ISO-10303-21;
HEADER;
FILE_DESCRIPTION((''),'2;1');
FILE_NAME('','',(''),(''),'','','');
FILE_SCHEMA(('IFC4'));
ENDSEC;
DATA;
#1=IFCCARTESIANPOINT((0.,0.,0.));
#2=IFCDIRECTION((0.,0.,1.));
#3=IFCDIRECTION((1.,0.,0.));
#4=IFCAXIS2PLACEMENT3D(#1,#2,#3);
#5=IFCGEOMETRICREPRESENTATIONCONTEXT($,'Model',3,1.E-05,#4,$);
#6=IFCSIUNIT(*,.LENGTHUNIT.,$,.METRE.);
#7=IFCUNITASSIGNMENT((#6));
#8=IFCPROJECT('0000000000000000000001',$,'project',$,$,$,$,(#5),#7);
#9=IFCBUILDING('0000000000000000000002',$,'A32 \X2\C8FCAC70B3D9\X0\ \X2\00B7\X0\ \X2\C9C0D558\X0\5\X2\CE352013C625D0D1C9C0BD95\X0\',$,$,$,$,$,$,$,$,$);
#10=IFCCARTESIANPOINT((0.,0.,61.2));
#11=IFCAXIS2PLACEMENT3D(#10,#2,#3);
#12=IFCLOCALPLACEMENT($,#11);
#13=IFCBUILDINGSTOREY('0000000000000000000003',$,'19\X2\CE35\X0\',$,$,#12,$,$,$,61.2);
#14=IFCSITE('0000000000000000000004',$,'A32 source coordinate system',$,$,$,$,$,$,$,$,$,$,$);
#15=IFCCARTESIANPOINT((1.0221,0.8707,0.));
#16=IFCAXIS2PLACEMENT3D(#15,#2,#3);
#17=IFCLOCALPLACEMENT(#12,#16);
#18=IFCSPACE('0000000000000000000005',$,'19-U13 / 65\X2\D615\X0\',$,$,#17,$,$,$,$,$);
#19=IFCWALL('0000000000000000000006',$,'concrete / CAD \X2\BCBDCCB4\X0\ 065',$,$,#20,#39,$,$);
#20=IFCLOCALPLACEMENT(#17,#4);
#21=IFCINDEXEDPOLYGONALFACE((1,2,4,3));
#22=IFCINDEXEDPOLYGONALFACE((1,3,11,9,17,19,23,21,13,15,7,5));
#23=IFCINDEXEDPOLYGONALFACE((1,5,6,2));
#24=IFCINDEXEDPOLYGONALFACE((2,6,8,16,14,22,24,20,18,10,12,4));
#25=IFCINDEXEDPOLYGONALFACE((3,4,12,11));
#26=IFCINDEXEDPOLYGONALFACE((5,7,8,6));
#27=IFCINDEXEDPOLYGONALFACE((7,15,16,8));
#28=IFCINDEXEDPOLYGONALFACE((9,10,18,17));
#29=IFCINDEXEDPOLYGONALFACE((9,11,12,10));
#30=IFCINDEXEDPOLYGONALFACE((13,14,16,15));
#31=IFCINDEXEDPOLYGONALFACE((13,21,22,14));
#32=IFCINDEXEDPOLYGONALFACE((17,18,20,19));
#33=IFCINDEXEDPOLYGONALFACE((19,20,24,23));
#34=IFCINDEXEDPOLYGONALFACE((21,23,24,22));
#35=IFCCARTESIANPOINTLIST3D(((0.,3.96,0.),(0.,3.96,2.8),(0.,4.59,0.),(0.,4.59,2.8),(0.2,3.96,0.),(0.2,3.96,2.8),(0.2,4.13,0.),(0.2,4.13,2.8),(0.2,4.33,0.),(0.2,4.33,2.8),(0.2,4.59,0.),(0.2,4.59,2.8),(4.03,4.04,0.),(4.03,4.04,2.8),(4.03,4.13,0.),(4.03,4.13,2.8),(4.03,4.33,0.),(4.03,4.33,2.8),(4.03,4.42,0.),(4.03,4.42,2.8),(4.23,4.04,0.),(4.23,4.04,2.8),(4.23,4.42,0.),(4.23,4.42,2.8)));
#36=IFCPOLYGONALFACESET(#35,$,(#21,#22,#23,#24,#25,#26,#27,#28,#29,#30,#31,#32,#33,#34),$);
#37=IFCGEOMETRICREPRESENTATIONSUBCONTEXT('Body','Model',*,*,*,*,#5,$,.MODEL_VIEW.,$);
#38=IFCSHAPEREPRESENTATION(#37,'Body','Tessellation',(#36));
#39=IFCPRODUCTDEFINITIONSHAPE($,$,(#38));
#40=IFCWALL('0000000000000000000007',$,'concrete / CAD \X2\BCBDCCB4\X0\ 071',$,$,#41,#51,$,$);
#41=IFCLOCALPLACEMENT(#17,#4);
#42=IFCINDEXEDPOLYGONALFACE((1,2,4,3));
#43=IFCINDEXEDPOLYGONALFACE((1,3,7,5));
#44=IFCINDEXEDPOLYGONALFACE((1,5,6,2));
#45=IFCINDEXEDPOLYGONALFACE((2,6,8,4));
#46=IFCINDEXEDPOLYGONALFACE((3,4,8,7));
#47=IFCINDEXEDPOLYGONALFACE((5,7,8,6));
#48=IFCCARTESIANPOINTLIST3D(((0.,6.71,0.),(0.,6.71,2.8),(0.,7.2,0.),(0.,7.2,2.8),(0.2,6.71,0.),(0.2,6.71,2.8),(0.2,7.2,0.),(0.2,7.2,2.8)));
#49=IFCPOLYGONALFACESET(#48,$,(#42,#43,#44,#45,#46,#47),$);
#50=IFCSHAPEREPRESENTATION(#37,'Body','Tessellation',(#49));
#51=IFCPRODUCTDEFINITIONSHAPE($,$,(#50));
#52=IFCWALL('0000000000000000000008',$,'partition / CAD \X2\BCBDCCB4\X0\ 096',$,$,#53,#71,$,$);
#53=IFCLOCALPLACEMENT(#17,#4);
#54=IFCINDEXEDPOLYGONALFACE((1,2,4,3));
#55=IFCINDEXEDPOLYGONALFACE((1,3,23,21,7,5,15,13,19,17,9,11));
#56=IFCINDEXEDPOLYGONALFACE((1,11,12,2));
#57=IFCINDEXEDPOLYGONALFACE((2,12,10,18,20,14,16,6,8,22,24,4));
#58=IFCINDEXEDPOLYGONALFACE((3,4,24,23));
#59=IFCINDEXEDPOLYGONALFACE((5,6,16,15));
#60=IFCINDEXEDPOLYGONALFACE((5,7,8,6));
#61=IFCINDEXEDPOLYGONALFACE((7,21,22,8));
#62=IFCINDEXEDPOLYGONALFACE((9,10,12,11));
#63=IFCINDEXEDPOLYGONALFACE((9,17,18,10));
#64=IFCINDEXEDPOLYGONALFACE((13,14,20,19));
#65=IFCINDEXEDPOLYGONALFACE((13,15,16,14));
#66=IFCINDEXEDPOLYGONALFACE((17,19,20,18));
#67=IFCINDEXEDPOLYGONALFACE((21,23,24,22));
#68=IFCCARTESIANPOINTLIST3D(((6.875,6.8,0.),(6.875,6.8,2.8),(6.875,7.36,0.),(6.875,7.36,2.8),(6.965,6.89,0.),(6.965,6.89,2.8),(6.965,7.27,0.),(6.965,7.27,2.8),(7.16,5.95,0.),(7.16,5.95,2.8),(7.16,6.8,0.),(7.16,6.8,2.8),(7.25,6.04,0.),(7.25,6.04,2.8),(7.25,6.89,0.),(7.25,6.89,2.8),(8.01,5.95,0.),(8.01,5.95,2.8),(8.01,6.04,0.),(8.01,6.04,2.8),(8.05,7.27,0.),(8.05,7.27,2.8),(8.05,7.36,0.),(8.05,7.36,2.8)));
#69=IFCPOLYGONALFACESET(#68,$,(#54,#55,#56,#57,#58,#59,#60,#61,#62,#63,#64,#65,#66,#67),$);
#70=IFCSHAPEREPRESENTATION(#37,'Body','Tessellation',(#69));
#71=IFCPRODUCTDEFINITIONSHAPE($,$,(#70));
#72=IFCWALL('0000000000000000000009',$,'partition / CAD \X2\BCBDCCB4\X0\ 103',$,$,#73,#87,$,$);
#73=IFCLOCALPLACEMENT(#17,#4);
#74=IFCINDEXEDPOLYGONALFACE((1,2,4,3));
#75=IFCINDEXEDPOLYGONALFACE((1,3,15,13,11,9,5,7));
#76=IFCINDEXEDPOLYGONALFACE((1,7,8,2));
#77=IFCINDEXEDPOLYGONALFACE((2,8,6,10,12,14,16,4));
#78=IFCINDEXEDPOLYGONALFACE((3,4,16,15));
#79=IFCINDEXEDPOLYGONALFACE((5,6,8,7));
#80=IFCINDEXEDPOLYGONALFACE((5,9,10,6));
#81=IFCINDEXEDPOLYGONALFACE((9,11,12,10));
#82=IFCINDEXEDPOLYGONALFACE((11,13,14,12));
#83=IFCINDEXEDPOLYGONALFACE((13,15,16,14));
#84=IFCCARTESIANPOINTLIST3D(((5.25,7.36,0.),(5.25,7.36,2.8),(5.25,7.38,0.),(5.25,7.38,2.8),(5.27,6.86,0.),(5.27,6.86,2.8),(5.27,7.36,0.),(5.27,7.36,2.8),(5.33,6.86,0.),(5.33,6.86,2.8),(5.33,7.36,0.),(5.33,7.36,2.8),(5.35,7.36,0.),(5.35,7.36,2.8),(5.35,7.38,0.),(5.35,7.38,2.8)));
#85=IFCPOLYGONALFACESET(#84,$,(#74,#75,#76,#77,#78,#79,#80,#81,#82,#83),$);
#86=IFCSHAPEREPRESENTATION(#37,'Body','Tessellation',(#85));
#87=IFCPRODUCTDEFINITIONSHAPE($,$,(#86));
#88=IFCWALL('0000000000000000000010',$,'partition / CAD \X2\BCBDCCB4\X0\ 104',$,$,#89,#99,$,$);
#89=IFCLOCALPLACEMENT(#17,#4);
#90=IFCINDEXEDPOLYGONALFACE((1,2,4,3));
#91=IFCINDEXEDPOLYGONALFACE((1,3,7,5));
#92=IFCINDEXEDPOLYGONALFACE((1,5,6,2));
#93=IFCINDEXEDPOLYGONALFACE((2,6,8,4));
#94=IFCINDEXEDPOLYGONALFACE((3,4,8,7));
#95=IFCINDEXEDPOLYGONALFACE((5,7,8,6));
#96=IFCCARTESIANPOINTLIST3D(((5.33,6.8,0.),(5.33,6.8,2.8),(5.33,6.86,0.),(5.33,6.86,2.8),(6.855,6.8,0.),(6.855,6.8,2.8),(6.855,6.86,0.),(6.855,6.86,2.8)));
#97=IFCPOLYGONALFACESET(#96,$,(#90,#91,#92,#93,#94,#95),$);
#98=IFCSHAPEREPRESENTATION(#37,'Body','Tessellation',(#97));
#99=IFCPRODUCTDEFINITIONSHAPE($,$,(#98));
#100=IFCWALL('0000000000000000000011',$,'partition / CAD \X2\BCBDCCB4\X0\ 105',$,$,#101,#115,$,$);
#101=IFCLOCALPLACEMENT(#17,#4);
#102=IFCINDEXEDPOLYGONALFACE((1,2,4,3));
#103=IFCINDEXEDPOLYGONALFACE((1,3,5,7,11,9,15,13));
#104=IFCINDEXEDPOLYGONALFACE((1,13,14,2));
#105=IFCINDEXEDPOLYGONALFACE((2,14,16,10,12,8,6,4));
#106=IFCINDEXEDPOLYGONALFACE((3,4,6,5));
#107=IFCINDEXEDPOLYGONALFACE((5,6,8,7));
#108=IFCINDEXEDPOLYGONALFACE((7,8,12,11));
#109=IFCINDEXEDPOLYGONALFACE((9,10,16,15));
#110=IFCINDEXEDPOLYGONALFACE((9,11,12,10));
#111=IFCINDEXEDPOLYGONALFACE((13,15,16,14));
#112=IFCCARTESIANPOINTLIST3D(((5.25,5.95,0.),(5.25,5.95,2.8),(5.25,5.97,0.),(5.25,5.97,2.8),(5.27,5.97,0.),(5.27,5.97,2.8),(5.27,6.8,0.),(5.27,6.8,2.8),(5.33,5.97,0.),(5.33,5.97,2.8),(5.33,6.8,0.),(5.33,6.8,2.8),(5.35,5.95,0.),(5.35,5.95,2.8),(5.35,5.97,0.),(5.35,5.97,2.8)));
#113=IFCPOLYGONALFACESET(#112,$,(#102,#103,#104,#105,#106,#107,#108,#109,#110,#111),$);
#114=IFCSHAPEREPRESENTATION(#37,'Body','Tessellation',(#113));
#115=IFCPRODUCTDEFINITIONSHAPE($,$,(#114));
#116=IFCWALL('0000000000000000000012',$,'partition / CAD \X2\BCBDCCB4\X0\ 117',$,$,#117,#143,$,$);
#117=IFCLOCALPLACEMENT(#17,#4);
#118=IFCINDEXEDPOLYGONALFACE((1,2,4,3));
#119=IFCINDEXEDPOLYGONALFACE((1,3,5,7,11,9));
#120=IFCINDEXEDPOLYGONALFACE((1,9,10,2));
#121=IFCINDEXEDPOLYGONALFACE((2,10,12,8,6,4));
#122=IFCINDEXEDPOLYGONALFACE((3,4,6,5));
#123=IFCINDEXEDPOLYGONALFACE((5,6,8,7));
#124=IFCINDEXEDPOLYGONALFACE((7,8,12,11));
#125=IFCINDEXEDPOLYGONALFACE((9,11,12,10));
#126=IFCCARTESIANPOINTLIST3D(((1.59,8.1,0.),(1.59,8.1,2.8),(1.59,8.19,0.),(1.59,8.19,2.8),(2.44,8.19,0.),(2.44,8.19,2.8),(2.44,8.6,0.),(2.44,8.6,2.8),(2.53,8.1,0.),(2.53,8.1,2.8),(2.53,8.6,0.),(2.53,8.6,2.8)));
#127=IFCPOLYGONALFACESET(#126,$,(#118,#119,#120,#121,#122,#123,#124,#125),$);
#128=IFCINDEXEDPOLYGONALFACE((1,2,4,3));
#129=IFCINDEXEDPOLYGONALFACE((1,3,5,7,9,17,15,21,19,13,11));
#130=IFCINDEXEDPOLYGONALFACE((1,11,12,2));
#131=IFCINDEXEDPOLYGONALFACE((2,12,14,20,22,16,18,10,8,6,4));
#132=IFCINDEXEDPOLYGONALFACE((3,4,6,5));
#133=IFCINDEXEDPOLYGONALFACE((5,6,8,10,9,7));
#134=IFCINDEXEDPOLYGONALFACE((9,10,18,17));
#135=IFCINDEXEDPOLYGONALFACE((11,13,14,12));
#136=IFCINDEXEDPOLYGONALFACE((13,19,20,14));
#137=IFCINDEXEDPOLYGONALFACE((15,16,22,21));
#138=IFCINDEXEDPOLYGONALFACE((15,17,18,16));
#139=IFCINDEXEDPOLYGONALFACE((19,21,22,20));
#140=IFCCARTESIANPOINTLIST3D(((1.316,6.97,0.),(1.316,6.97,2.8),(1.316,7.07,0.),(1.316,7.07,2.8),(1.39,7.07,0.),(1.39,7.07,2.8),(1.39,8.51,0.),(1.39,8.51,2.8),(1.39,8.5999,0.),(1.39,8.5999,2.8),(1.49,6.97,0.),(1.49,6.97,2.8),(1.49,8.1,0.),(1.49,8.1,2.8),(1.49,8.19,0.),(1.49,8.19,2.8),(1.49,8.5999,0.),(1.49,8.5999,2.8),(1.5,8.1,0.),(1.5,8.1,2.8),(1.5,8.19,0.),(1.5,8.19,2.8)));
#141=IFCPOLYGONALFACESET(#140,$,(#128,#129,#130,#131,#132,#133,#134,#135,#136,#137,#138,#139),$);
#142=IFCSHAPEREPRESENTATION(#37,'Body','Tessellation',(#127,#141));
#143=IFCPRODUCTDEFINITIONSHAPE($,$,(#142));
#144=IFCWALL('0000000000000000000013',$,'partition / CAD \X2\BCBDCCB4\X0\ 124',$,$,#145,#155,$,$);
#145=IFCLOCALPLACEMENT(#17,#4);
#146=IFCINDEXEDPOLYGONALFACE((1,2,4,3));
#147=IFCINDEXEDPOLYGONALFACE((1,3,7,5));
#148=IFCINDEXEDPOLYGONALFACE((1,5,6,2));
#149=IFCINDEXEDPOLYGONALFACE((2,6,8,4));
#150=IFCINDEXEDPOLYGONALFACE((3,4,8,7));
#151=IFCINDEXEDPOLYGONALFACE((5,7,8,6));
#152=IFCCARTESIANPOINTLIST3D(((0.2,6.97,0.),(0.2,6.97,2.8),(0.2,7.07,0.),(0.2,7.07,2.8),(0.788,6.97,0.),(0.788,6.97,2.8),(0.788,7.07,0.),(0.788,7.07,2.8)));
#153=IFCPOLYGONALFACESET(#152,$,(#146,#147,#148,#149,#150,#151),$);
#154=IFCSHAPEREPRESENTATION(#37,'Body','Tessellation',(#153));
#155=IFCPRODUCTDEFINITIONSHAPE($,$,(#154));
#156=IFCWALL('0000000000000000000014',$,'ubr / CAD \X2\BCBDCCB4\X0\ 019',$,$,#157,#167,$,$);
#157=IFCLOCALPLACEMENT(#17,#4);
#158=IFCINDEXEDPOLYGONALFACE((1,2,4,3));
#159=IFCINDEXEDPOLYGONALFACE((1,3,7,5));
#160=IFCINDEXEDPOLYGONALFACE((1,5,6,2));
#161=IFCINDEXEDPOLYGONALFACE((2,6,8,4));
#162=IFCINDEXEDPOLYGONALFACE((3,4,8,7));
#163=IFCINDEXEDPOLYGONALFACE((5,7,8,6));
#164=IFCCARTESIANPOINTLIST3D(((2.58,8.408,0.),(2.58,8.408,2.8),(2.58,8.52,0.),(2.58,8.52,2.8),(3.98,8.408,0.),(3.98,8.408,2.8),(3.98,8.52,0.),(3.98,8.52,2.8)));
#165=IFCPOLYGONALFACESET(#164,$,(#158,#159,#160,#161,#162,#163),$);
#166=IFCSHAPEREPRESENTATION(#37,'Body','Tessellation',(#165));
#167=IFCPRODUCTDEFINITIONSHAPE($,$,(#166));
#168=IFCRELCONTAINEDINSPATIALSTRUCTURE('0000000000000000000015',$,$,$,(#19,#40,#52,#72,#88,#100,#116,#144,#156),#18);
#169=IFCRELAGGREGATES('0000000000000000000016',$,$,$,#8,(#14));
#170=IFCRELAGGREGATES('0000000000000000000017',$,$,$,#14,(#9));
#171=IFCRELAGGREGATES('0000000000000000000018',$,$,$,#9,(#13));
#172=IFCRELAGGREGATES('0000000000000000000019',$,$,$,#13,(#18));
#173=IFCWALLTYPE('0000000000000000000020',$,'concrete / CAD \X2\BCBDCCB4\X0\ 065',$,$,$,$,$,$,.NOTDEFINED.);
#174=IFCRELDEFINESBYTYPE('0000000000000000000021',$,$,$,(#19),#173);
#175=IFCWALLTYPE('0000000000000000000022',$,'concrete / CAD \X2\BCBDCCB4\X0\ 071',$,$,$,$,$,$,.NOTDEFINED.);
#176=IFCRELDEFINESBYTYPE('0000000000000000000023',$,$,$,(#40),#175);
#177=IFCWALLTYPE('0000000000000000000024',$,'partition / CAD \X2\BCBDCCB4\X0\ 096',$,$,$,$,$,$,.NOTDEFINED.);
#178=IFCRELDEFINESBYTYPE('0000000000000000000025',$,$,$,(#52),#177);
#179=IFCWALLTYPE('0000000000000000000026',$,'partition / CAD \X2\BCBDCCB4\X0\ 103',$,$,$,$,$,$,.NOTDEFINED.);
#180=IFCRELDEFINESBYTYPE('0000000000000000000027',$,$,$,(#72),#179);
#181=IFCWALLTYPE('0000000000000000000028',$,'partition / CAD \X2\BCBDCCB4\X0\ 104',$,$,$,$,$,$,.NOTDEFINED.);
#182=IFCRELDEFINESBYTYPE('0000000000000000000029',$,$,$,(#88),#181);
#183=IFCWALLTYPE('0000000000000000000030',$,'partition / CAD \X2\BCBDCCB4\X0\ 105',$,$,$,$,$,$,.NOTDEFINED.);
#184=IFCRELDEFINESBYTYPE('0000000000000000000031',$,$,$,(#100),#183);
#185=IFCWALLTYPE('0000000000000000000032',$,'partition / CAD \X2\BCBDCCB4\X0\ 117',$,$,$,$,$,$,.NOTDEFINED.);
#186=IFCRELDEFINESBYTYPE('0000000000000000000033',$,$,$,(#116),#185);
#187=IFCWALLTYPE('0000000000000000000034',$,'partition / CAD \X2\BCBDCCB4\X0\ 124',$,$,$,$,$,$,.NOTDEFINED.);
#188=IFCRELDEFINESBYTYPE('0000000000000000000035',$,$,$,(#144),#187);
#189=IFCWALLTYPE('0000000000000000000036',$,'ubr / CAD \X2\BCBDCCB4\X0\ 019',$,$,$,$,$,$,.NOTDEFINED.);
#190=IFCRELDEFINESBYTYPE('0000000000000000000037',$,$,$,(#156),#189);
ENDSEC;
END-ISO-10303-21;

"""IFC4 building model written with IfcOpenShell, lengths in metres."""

from ifc_helpers import new_model, si_unit, frame, origin, origin_with_axes, place, context, subcontext, project, spatial, polyline, outline, extrude, source, transform, mapped, type_object, type_shapes, element, save


model = new_model("IFC4")

# Units and contexts
model_context = context("Model", 3, precision=1e-05, world=origin_with_axes())
body_context = subcontext(model_context, "Body", "Model", "MODEL_VIEW")
ifc_project = project(units=[si_unit("LENGTHUNIT", "METRE")], contexts=[model_context])

# Site, building, storey, space
storey_placement = place(None, frame((0.0, 0.0, 61.2), z_axis=(0.0, 0.0, 1.0), x_axis=(1.0, 0.0, 0.0)))
space_placement = place(storey_placement, frame((1.0221, 0.8707, 0.0), z_axis=(0.0, 0.0, 1.0), x_axis=(1.0, 0.0, 0.0)))
site = spatial("IfcSite", under=ifc_project, Name="A32 source coordinate system")
building = spatial("IfcBuilding", under=site, Name="A32 주거동 · 지하5층–옥탑지붕")
storey = spatial("IfcBuildingStorey", under=building, at=storey_placement, Name="19층", Elevation=61.2)
space = spatial("IfcSpace", under=storey, at=space_placement, Name="19-U13 / 65형")

# Walls
wall_type_1 = type_object("IfcWallType", Name="concrete / CAD 벽체 065", PredefinedType="NOTDEFINED")
shared_shape_1 = source(origin(), body_context, "Body", "SweptSolid", [
    extrude(outline(polyline([(0.2, 4.59), (0.2, 4.33), (4.03, 4.33), (4.03, 4.42), (4.23, 4.42), (4.23, 4.04), (4.03, 4.04), (4.03, 4.13), (0.2, 4.13), (0.2, 3.96), (0.0, 3.96), (0.0, 4.59), (0.2, 4.59)])), origin(), (0.0, 0.0, 1.0), 2.8),
])
type_shapes(wall_type_1, [shared_shape_1])
wall_1_placement = place(space_placement, origin_with_axes())
element("IfcWall", 1, at=wall_1_placement, inside=space, type_object=wall_type_1, Name="concrete / CAD 벽체 065", context=body_context, shape_type="MappedRepresentation", body=[
    mapped(shared_shape_1, transform((0.0, 0.0, 0.0), scale=1.0)),
])
wall_type_2 = type_object("IfcWallType", Name="concrete / CAD 벽체 071", PredefinedType="NOTDEFINED")
shared_shape_2 = source(origin(), body_context, "Body", "SweptSolid", [
    extrude(outline(polyline([(0.2, 6.71), (0.0, 6.71), (0.0, 7.2), (0.2, 7.2), (0.2, 6.71)])), origin(), (0.0, 0.0, 1.0), 2.8),
])
type_shapes(wall_type_2, [shared_shape_2])
wall_2_placement = place(space_placement, origin_with_axes())
element("IfcWall", 2, at=wall_2_placement, inside=space, type_object=wall_type_2, Name="concrete / CAD 벽체 071", context=body_context, shape_type="MappedRepresentation", body=[
    mapped(shared_shape_2, transform((0.0, 0.0, 0.0), scale=1.0)),
])
wall_type_3 = type_object("IfcWallType", Name="partition / CAD 벽체 096", PredefinedType="NOTDEFINED")
shared_shape_3 = source(origin(), body_context, "Body", "SweptSolid", [
    extrude(outline(polyline([(7.25, 6.04), (8.01, 6.04), (8.01, 5.95), (7.16, 5.95), (7.16, 6.8), (6.875, 6.8), (6.875, 7.36), (8.05, 7.36), (8.05, 7.27), (6.965, 7.27), (6.965, 6.89), (7.25, 6.89), (7.25, 6.04)])), origin(), (0.0, 0.0, 1.0), 2.8),
])
type_shapes(wall_type_3, [shared_shape_3])
wall_3_placement = place(space_placement, origin_with_axes())
element("IfcWall", 3, at=wall_3_placement, inside=space, type_object=wall_type_3, Name="partition / CAD 벽체 096", context=body_context, shape_type="MappedRepresentation", body=[
    mapped(shared_shape_3, transform((0.0, 0.0, 0.0), scale=1.0)),
])
wall_type_4 = type_object("IfcWallType", Name="partition / CAD 벽체 103", PredefinedType="NOTDEFINED")
shared_shape_4 = source(origin(), body_context, "Body", "SweptSolid", [
    extrude(outline(polyline([(5.27, 7.36), (5.25, 7.36), (5.25, 7.38), (5.35, 7.38), (5.35, 7.36), (5.33, 7.36), (5.33, 6.86), (5.27, 6.86), (5.27, 7.36)])), origin(), (0.0, 0.0, 1.0), 2.8),
])
type_shapes(wall_type_4, [shared_shape_4])
wall_4_placement = place(space_placement, origin_with_axes())
element("IfcWall", 4, at=wall_4_placement, inside=space, type_object=wall_type_4, Name="partition / CAD 벽체 103", context=body_context, shape_type="MappedRepresentation", body=[
    mapped(shared_shape_4, transform((0.0, 0.0, 0.0), scale=1.0)),
])
wall_type_5 = type_object("IfcWallType", Name="partition / CAD 벽체 104", PredefinedType="NOTDEFINED")
shared_shape_5 = source(origin(), body_context, "Body", "SweptSolid", [
    extrude(outline(polyline([(6.855, 6.86), (6.855, 6.8), (5.33, 6.8), (5.33, 6.86), (6.855, 6.86)])), origin(), (0.0, 0.0, 1.0), 2.8),
])
type_shapes(wall_type_5, [shared_shape_5])
wall_5_placement = place(space_placement, origin_with_axes())
element("IfcWall", 5, at=wall_5_placement, inside=space, type_object=wall_type_5, Name="partition / CAD 벽체 104", context=body_context, shape_type="MappedRepresentation", body=[
    mapped(shared_shape_5, transform((0.0, 0.0, 0.0), scale=1.0)),
])
wall_type_6 = type_object("IfcWallType", Name="partition / CAD 벽체 105", PredefinedType="NOTDEFINED")
shared_shape_6 = source(origin(), body_context, "Body", "SweptSolid", [
    extrude(outline(polyline([(5.25, 5.97), (5.27, 5.97), (5.27, 6.8), (5.33, 6.8), (5.33, 5.97), (5.35, 5.97), (5.35, 5.95), (5.25, 5.95), (5.25, 5.97)])), origin(), (0.0, 0.0, 1.0), 2.8),
])
type_shapes(wall_type_6, [shared_shape_6])
wall_6_placement = place(space_placement, origin_with_axes())
element("IfcWall", 6, at=wall_6_placement, inside=space, type_object=wall_type_6, Name="partition / CAD 벽체 105", context=body_context, shape_type="MappedRepresentation", body=[
    mapped(shared_shape_6, transform((0.0, 0.0, 0.0), scale=1.0)),
])
wall_type_7 = type_object("IfcWallType", Name="partition / CAD 벽체 117", PredefinedType="NOTDEFINED")
shared_shape_7 = source(origin(), body_context, "Body", "SweptSolid", [
    extrude(outline(polyline([(2.53, 8.1), (1.59, 8.1), (1.59, 8.19), (2.44, 8.19), (2.44, 8.6), (2.53, 8.6), (2.53, 8.1)])), origin(), (0.0, 0.0, 1.0), 2.8),
    extrude(outline(polyline([(1.49, 8.1), (1.49, 6.97), (1.316, 6.97), (1.316, 7.07), (1.39, 7.07), (1.39, 8.51), (1.39, 8.5999), (1.49, 8.5999), (1.49, 8.19), (1.5, 8.19), (1.5, 8.1), (1.49, 8.1)])), origin(), (0.0, 0.0, 1.0), 2.8),
])
type_shapes(wall_type_7, [shared_shape_7])
wall_7_placement = place(space_placement, origin_with_axes())
element("IfcWall", 7, at=wall_7_placement, inside=space, type_object=wall_type_7, Name="partition / CAD 벽체 117", context=body_context, shape_type="MappedRepresentation", body=[
    mapped(shared_shape_7, transform((0.0, 0.0, 0.0), scale=1.0)),
])
wall_type_8 = type_object("IfcWallType", Name="partition / CAD 벽체 124", PredefinedType="NOTDEFINED")
shared_shape_8 = source(origin(), body_context, "Body", "SweptSolid", [
    extrude(outline(polyline([(0.788, 7.07), (0.788, 6.97), (0.2, 6.97), (0.2, 7.07), (0.788, 7.07)])), origin(), (0.0, 0.0, 1.0), 2.8),
])
type_shapes(wall_type_8, [shared_shape_8])
wall_8_placement = place(space_placement, origin_with_axes())
element("IfcWall", 8, at=wall_8_placement, inside=space, type_object=wall_type_8, Name="partition / CAD 벽체 124", context=body_context, shape_type="MappedRepresentation", body=[
    mapped(shared_shape_8, transform((0.0, 0.0, 0.0), scale=1.0)),
])
wall_type_9 = type_object("IfcWallType", Name="ubr / CAD 벽체 019", PredefinedType="NOTDEFINED")
shared_shape_9 = source(origin(), body_context, "Body", "SweptSolid", [
    extrude(outline(polyline([(3.98, 8.408), (2.58, 8.408), (2.58, 8.52), (3.98, 8.52), (3.98, 8.408)])), origin(), (0.0, 0.0, 1.0), 2.8),
])
type_shapes(wall_type_9, [shared_shape_9])
wall_9_placement = place(space_placement, origin_with_axes())
element("IfcWall", 9, at=wall_9_placement, inside=space, type_object=wall_type_9, Name="ubr / CAD 벽체 019", context=body_context, shape_type="MappedRepresentation", body=[
    mapped(shared_shape_9, transform((0.0, 0.0, 0.0), scale=1.0)),
])

save(model, "model.ifc")
